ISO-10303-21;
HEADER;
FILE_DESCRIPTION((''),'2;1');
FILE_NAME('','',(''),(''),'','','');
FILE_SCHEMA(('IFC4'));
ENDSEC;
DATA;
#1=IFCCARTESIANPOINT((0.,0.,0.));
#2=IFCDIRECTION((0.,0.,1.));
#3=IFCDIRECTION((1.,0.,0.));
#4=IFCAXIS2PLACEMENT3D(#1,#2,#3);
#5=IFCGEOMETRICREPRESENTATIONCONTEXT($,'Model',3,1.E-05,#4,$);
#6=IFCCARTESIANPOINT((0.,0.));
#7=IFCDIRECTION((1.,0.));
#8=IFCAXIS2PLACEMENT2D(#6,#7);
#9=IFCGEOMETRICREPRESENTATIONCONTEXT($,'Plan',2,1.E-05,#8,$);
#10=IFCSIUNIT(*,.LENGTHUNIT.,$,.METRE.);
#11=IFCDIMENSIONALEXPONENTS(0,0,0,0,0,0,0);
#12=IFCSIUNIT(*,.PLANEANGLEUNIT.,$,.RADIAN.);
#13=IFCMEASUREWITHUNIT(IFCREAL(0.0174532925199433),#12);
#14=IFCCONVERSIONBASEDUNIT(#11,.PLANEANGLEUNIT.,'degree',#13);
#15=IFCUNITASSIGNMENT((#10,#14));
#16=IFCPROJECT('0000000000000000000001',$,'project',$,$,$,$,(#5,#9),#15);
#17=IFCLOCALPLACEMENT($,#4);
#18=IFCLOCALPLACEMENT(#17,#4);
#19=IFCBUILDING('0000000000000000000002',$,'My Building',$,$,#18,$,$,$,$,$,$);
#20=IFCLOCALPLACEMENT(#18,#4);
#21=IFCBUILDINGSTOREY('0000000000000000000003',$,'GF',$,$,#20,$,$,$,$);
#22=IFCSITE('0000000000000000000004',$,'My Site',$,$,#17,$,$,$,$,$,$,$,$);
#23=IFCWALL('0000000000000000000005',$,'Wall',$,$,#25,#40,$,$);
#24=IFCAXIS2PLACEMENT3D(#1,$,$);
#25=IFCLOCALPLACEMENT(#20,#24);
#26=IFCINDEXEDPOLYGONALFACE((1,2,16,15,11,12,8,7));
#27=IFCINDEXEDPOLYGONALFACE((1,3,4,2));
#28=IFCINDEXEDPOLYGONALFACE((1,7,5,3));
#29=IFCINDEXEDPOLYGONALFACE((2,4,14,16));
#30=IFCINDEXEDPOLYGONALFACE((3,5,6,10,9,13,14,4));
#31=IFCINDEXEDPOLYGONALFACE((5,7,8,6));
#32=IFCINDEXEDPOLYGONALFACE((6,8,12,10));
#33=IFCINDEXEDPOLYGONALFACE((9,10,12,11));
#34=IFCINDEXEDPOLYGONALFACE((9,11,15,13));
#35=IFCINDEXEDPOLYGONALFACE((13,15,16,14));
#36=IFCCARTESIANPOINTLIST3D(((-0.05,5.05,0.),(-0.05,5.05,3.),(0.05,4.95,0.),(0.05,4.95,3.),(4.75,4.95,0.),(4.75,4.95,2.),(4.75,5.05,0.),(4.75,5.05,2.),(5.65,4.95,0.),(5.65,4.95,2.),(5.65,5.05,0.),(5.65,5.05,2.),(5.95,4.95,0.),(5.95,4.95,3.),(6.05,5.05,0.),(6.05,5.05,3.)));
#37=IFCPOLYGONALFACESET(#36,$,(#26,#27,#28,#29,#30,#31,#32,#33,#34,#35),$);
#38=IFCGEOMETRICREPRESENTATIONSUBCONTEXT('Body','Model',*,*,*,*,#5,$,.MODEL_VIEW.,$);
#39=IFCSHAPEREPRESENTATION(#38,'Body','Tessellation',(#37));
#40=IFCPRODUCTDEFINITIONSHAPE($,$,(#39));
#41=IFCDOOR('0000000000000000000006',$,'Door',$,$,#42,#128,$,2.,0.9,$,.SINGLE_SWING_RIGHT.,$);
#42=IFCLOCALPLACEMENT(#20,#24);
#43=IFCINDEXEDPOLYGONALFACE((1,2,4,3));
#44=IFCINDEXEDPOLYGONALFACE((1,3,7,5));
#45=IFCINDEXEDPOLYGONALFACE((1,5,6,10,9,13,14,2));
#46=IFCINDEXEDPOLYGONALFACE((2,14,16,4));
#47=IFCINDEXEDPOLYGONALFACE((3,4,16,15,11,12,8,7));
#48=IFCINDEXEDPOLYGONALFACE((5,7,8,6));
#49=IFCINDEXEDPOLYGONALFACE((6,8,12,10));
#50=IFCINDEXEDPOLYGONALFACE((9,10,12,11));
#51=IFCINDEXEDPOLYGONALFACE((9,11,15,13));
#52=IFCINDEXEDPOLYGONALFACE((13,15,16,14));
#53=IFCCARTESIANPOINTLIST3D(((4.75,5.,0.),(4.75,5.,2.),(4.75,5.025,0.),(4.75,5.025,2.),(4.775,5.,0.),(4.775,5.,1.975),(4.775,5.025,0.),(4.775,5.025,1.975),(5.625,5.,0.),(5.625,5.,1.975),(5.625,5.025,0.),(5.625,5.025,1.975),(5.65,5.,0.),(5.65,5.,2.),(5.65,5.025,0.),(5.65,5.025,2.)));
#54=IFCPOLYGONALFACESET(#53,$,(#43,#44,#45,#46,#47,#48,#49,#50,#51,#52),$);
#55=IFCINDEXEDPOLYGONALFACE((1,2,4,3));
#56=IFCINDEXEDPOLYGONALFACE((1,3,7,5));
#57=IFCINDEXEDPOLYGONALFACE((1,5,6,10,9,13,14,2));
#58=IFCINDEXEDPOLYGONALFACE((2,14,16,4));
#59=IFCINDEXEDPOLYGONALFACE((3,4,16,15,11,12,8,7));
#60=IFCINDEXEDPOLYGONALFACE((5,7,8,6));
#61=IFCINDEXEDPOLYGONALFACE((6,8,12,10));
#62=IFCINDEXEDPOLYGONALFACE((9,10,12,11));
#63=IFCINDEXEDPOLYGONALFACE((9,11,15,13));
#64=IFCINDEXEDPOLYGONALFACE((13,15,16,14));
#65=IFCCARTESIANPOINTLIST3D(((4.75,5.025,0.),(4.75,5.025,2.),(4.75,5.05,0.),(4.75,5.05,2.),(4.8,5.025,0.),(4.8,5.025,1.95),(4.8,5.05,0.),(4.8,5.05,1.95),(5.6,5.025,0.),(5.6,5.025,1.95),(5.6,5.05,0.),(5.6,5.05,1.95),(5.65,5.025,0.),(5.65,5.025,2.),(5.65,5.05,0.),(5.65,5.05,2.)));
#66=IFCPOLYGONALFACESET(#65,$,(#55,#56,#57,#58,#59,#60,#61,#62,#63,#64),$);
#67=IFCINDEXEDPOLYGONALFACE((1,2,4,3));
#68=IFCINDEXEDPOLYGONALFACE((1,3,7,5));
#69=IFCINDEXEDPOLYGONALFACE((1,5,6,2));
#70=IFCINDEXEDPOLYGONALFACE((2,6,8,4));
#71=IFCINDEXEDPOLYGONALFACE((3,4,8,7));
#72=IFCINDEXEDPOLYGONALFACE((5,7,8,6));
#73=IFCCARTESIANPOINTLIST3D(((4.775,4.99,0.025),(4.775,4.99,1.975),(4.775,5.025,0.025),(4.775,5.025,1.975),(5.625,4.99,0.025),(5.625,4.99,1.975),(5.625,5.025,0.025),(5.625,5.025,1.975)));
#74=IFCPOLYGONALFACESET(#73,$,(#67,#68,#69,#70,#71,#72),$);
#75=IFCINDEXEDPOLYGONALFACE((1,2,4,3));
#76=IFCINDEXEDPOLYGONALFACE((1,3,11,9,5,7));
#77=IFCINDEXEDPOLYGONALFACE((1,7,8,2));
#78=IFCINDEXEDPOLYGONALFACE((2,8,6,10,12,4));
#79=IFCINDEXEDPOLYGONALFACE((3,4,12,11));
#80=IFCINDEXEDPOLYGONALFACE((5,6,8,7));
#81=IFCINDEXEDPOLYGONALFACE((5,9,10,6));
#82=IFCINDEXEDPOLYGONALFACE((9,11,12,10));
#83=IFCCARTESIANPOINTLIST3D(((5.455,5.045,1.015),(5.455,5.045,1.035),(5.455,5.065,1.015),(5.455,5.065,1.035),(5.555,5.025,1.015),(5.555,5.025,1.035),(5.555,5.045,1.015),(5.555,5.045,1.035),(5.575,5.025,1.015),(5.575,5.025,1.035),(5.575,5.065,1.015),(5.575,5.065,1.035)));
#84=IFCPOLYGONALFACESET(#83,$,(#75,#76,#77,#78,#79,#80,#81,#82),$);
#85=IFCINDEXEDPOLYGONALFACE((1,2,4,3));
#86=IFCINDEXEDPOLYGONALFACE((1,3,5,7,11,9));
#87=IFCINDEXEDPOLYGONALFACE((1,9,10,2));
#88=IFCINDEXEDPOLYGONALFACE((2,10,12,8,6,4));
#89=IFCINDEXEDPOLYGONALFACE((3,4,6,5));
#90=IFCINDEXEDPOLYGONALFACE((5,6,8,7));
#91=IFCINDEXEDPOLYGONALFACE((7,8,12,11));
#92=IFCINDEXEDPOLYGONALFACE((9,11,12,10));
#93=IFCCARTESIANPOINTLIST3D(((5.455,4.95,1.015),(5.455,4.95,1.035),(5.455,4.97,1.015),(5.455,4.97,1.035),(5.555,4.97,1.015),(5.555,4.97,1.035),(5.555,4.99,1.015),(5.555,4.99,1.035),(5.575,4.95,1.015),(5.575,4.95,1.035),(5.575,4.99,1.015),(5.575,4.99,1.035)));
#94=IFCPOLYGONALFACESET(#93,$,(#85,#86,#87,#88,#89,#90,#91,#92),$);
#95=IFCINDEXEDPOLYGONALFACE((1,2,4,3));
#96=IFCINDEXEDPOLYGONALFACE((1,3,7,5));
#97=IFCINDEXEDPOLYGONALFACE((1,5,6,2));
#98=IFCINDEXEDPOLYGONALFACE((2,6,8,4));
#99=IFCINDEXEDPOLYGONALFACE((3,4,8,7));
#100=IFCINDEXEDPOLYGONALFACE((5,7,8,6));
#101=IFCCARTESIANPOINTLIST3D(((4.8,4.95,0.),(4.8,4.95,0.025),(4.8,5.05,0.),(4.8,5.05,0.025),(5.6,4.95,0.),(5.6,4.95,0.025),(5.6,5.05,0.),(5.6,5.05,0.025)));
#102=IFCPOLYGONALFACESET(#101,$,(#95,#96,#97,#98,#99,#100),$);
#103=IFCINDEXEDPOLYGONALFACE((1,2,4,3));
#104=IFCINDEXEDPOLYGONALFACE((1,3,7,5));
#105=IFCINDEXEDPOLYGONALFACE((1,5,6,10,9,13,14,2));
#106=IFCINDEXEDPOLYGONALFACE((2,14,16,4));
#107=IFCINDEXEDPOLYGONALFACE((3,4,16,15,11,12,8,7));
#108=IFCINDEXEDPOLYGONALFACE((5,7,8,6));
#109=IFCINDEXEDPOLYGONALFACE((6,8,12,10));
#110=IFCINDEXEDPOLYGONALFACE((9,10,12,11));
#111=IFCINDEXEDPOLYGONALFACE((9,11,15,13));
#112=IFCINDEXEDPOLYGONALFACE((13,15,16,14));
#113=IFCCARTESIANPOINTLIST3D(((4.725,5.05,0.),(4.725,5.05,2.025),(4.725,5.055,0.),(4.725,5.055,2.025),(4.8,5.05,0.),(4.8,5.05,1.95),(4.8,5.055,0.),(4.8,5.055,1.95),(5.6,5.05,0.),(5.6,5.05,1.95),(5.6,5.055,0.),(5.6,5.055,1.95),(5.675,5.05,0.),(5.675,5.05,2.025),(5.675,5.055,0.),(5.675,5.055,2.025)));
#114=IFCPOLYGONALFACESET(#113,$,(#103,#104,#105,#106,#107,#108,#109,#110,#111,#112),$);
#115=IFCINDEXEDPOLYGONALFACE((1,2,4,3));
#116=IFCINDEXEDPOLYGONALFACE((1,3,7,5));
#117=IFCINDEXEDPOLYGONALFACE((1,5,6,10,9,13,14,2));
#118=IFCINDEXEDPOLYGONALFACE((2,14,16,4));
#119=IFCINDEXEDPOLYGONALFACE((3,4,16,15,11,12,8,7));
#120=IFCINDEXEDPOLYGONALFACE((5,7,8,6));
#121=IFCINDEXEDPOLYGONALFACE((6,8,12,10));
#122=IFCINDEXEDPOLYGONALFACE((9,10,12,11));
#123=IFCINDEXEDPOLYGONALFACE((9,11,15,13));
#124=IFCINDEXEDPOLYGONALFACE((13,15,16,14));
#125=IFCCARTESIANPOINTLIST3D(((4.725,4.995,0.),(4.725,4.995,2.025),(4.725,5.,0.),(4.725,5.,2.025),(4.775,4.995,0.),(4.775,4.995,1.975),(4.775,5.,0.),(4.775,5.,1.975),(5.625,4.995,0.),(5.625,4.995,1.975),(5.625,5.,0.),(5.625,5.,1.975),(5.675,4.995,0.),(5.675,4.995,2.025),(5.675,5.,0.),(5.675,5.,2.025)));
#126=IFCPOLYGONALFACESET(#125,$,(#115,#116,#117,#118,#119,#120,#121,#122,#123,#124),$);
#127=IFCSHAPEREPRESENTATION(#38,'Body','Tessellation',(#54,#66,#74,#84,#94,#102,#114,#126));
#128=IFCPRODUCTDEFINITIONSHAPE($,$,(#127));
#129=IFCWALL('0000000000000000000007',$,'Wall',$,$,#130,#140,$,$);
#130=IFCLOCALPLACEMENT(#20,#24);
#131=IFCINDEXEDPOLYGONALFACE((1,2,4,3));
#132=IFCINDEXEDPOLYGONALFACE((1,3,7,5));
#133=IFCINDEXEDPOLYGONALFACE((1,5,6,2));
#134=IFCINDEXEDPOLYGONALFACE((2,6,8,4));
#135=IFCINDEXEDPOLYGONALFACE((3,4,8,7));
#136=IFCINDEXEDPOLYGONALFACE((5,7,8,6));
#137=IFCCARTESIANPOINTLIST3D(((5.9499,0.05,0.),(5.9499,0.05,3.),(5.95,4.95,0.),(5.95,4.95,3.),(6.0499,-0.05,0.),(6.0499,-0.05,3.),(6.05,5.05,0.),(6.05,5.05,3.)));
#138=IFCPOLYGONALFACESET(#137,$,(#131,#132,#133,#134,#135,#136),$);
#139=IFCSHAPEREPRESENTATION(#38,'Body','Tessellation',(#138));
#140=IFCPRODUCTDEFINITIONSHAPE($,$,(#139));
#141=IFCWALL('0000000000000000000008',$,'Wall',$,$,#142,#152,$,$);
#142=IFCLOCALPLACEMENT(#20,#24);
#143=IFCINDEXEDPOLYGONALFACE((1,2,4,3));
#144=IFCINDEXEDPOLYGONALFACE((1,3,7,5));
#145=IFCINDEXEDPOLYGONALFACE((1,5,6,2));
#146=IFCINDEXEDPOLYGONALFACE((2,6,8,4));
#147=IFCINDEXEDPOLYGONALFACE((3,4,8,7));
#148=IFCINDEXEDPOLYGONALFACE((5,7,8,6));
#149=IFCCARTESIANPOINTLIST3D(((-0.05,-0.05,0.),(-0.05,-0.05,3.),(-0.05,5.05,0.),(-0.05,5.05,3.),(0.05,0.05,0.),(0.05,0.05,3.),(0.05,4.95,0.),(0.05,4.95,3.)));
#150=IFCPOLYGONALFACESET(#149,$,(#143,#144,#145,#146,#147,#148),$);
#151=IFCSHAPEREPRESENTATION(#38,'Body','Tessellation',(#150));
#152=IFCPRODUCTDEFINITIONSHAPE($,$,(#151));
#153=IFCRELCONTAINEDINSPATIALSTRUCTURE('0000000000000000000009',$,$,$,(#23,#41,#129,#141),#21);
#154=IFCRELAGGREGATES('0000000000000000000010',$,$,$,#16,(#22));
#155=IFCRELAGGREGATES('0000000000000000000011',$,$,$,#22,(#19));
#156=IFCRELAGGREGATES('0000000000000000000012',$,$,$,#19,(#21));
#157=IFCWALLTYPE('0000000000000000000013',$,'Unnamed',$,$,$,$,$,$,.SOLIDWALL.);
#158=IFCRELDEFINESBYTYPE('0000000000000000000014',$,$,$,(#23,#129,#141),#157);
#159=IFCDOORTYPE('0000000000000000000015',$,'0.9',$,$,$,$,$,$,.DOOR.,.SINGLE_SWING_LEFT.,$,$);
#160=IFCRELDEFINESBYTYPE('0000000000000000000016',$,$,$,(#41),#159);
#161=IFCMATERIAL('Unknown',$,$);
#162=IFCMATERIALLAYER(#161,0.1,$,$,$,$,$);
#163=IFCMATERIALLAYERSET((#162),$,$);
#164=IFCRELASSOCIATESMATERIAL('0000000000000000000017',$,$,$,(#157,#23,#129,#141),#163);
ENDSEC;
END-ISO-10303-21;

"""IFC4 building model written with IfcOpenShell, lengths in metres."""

from ifc_helpers import new_model, entity, si_unit, converted_unit, frame, origin_with_axes, origin_2d_with_axis, place, context, subcontext, project, spatial, line, indexed_curve, outline, extrude, shape, source, transform, mapped, material, layer, layer_set, layer_usage, type_object, type_shapes, element, fill, save


model = new_model("IFC4")

# Units and contexts
model_context = context("Model", 3, precision=1e-05, world=origin_with_axes())
plan_context = context("Plan", 2, precision=1e-05, world=origin_2d_with_axis())
body_context_1 = subcontext(model_context, "Body", "Model", "MODEL_VIEW")
body_context_2 = subcontext(plan_context, "Body", "Plan", "PLAN_VIEW")
ifc_project = project(units=[si_unit("LENGTHUNIT", "METRE"), converted_unit("PLANEANGLEUNIT", "degree", entity("IfcReal", 0.0174532925199433), si_unit("PLANEANGLEUNIT", "RADIAN"), dimensions=[0, 0, 0, 0, 0, 0, 0])], contexts=[model_context, plan_context])

# Site, building, storey
site_placement = place(None, origin_with_axes())
site = spatial("IfcSite", under=ifc_project, at=site_placement, Name="My Site")
building_placement = place(site_placement, origin_with_axes())
building = spatial("IfcBuilding", under=site, at=building_placement, Name="My Building")
storey_placement = place(building_placement, origin_with_axes())
storey = spatial("IfcBuildingStorey", under=building, at=storey_placement, Name="GF")

# Shared definitions
ifc_material = material(Name="Unknown")

# Wall, opening, door
ifc_layer_1 = layer(ifc_material, 0.1)
ifc_layer_set_1 = layer_set([ifc_layer_1])
ifc_layer_usage_1 = layer_usage(ifc_layer_set_1, "AXIS2", "POSITIVE", 0.0)
wall_type = type_object("IfcWallType", Name="Unnamed", PredefinedType="SOLIDWALL", material=ifc_layer_set_1)
wall_1_placement = place(storey_placement, frame((0.05, 4.95, 0.0), z_axis=(0.0, 0.0, 1.0), x_axis=(1.0, 0.0, 0.0)))
wall_1 = element("IfcWall", 1, at=wall_1_placement, inside=storey, type_object=wall_type, material=ifc_layer_usage_1, Name="Wall", context=body_context_1, shape_type="SweptSolid", body=[
    extrude(outline(indexed_curve([(0.0, 0.0), (-0.1, 0.1), (6.0, 0.1), (5.9, 0.0)], segments=[line(1, 2, 3, 4, 1)])), origin_with_axes(), (0.0, 0.0, 1.0), 3.0),
])
shared_shape_1 = source(origin_with_axes(), body_context_1, "Body", "SweptSolid", [
    extrude(outline(indexed_curve([(0.0, 0.0), (0.9, 0.0), (0.9, 2.0), (0.0, 2.0)], segments=[line(1, 2, 3, 4, 1)])), frame((0.0, -0.6, 0.0), z_axis=(0.0, -1.0, 0.0), x_axis=(1.0, 0.0, 0.0)), (0.0, 0.0, -1.0), 1.2),
])
opening_1_placement = place(wall_1_placement, frame((5.6, 0.1, 0.0), z_axis=(0.0, 0.0, 1.0), x_axis=(-1.0, 0.0, 0.0)))
opening_1 = element("IfcOpeningElement", 2, at=opening_1_placement, cuts=wall_1, PredefinedType="OPENING", context=body_context_1, shape_type="MappedRepresentation", body=[
    mapped(shared_shape_1, transform((0.0, 0.0, 0.0), x_axis=(1.0, 0.0, 0.0), y_axis=(0.0, 1.0, 0.0), z_axis=(0.0, 0.0, 1.0), scale=1.0)),
])
door_type_1 = type_object("IfcDoorType", Name="0.9", OperationType="SINGLE_SWING_LEFT", PredefinedType="DOOR")
shared_shape_2 = source(origin_with_axes(), body_context_1, "Body", "SweptSolid", [
    extrude(outline(indexed_curve([(0.0, 0.0), (0.0, 2.0), (0.9, 2.0), (0.9, 0.0), (0.875, 0.0), (0.875, 1.975), (0.025, 1.975), (0.025, 0.0)], segments=[line(1, 2, 3, 4, 5, 6, 7, 8, 1)])), frame((0.0, 0.025, 0.0), z_axis=(0.0, -1.0, 0.0), x_axis=(1.0, 0.0, 0.0)), (0.0, 0.0, -1.0), 0.025),
    extrude(outline(indexed_curve([(0.0, 0.0), (0.0, 2.0), (0.9, 2.0), (0.9, 0.0), (0.85, 0.0), (0.85, 1.95), (0.05, 1.95), (0.05, 0.0)], segments=[line(1, 2, 3, 4, 5, 6, 7, 8, 1)])), frame((0.0, 0.0, 0.0), z_axis=(0.0, -1.0, 0.0), x_axis=(1.0, 0.0, 0.0)), (0.0, 0.0, -1.0), 0.025),
    extrude(outline(indexed_curve([(0.0, 0.0), (0.85, 0.0), (0.85, 0.035), (0.0, 0.035)], segments=[line(1, 2, 3, 4, 1)])), frame((0.025, 0.025, 0.025), z_axis=(0.0, 0.0, 1.0), x_axis=(1.0, 0.0, 0.0)), (0.0, 0.0, 1.0), 1.95),
    extrude(outline(indexed_curve([(0.0, 0.0), (0.0, -0.04), (0.12, -0.04), (0.12, -0.02), (0.02, -0.02), (0.02, 0.0)], segments=[line(1, 2, 3, 4, 5, 6, 1)])), frame((0.075, 0.025, 1.015), z_axis=(0.0, 0.0, 1.0), x_axis=(1.0, 0.0, 0.0)), (0.0, 0.0, 1.0), 0.02),
    extrude(outline(indexed_curve([(0.0, 0.0), (0.0, 0.04), (0.12, 0.04), (0.12, 0.02), (0.02, 0.02), (0.02, 0.0)], segments=[line(1, 2, 3, 4, 5, 6, 1)])), frame((0.075, 0.06, 1.015), z_axis=(0.0, 0.0, 1.0), x_axis=(1.0, 0.0, 0.0)), (0.0, 0.0, 1.0), 0.02),
    extrude(outline(indexed_curve([(0.0, 0.0), (0.8, 0.0), (0.8, 0.1), (0.0, 0.1)], segments=[line(1, 2, 3, 4, 1)])), frame((0.05, 0.0, 0.0), z_axis=(0.0, 0.0, 1.0), x_axis=(1.0, 0.0, 0.0)), (0.0, 0.0, 1.0), 0.025),
    extrude(outline(indexed_curve([(0.0, 0.0), (0.0, 2.025), (0.95, 2.025), (0.95, 0.0), (0.875, 0.0), (0.875, 1.95), (0.075, 1.95), (0.075, 0.0)], segments=[line(1, 2, 3, 4, 5, 6, 7, 8, 1)])), frame((-0.025, -0.005, 0.0), z_axis=(0.0, -1.0, 0.0), x_axis=(1.0, 0.0, 0.0)), (0.0, 0.0, -1.0), 0.005),
    extrude(outline(indexed_curve([(0.0, 0.0), (0.0, 2.025), (0.95, 2.025), (0.95, 0.0), (0.9, 0.0), (0.9, 1.975), (0.05, 1.975), (0.05, 0.0)], segments=[line(1, 2, 3, 4, 5, 6, 7, 8, 1)])), frame((-0.025, 0.05, 0.0), z_axis=(0.0, -1.0, 0.0), x_axis=(1.0, 0.0, 0.0)), (0.0, 0.0, -1.0), 0.005),
])
shared_shape_3 = source(origin_with_axes(), body_context_2, "Body", "Curve2D", [
    entity("IfcIndexedPolyCurve", entity("IfcCartesianPointList2D", [[0.0, 0.0], [0.0, 0.05], [0.025, 0.05], [0.025, 0.025], [0.05, 0.025], [0.05, 0.0]]), [entity("IfcLineIndex", [1, 2, 3, 4, 5, 6, 1])]),
    entity("IfcIndexedPolyCurve", entity("IfcCartesianPointList2D", [[0.9, 0.0], [0.9, 0.05], [0.875, 0.05], [0.875, 0.025], [0.85, 0.025], [0.85, 0.0]]), [entity("IfcLineIndex", [1, 2, 3, 4, 5, 6, 1])]),
    entity("IfcTrimmedCurve", entity("IfcEllipse", entity("IfcAxis2Placement2D", entity("IfcCartesianPoint", [0.84, 0.05]), entity("IfcDirection", [1.0, 0.0])), 0.815, 0.85), [entity("IfcCartesianPoint", [0.84, 0.9])], [entity("IfcCartesianPoint", [0.025, 0.05])], True, "CARTESIAN"),
    entity("IfcIndexedPolyCurve", entity("IfcCartesianPointList2D", [[0.875, 0.05], [0.84, 0.05], [0.84, 0.9], [0.875, 0.9]]), [entity("IfcLineIndex", [1, 2, 3, 4, 1])]),
])
type_shapes(door_type_1, [shared_shape_2, shared_shape_3])
door_1_placement = place(opening_1_placement, origin_with_axes())
door_1 = element("IfcDoor", 3, at=door_1_placement, inside=storey, type_object=door_type_1, Name="Door", OperationType="SINGLE_SWING_RIGHT", OverallHeight=2.0, OverallWidth=0.9, shapes=[
    shape(body_context_1, "Body", "MappedRepresentation", [mapped(shared_shape_2, transform((0.0, 0.0, 0.0), x_axis=(1.0, 0.0, 0.0), y_axis=(0.0, 1.0, 0.0), z_axis=(0.0, 0.0, 1.0), scale=1.0))]),
    shape(body_context_2, "Body", "MappedRepresentation", [mapped(shared_shape_3, transform((0.0, 0.0, 0.0), x_axis=(1.0, 0.0, 0.0), y_axis=(0.0, 1.0, 0.0), z_axis=(0.0, 0.0, 1.0), scale=1.0))]),
])
fill(opening_1, door_1)

# Wall
ifc_layer_usage_2 = layer_usage(ifc_layer_set_1, "AXIS2", "POSITIVE", 0.0)
wall_2_placement = place(storey_placement, frame((5.95, 4.95, 0.0), z_axis=(0.0, 0.0, 1.0), x_axis=(-0.000012, -1.0, 0.0)))
element("IfcWall", 4, at=wall_2_placement, inside=storey, type_object=wall_type, material=ifc_layer_usage_2, Name="Wall", context=body_context_1, shape_type="SweptSolid", body=[
    extrude(outline(indexed_curve([(0.0, 0.0), (-0.1, 0.1), (5.0, 0.1), (4.9, 0.0)], segments=[line(1, 2, 3, 4, 1)])), origin_with_axes(), (0.0, 0.0, 1.0), 3.0),
])

# Wall
ifc_layer_usage_3 = layer_usage(ifc_layer_set_1, "AXIS2", "POSITIVE", 0.0)
wall_3_placement = place(storey_placement, frame((0.05, 0.05, 0.0), z_axis=(0.0, 0.0, 1.0), x_axis=(0.0, 1.0, 0.0)))
element("IfcWall", 5, at=wall_3_placement, inside=storey, type_object=wall_type, material=ifc_layer_usage_3, Name="Wall", context=body_context_1, shape_type="SweptSolid", body=[
    extrude(outline(indexed_curve([(0.0, 0.0), (-0.1, 0.1), (5.0, 0.1), (4.9, 0.0)], segments=[line(1, 2, 3, 4, 1)])), origin_with_axes(), (0.0, 0.0, 1.0), 3.0),
])

save(model, "model.ifc")
